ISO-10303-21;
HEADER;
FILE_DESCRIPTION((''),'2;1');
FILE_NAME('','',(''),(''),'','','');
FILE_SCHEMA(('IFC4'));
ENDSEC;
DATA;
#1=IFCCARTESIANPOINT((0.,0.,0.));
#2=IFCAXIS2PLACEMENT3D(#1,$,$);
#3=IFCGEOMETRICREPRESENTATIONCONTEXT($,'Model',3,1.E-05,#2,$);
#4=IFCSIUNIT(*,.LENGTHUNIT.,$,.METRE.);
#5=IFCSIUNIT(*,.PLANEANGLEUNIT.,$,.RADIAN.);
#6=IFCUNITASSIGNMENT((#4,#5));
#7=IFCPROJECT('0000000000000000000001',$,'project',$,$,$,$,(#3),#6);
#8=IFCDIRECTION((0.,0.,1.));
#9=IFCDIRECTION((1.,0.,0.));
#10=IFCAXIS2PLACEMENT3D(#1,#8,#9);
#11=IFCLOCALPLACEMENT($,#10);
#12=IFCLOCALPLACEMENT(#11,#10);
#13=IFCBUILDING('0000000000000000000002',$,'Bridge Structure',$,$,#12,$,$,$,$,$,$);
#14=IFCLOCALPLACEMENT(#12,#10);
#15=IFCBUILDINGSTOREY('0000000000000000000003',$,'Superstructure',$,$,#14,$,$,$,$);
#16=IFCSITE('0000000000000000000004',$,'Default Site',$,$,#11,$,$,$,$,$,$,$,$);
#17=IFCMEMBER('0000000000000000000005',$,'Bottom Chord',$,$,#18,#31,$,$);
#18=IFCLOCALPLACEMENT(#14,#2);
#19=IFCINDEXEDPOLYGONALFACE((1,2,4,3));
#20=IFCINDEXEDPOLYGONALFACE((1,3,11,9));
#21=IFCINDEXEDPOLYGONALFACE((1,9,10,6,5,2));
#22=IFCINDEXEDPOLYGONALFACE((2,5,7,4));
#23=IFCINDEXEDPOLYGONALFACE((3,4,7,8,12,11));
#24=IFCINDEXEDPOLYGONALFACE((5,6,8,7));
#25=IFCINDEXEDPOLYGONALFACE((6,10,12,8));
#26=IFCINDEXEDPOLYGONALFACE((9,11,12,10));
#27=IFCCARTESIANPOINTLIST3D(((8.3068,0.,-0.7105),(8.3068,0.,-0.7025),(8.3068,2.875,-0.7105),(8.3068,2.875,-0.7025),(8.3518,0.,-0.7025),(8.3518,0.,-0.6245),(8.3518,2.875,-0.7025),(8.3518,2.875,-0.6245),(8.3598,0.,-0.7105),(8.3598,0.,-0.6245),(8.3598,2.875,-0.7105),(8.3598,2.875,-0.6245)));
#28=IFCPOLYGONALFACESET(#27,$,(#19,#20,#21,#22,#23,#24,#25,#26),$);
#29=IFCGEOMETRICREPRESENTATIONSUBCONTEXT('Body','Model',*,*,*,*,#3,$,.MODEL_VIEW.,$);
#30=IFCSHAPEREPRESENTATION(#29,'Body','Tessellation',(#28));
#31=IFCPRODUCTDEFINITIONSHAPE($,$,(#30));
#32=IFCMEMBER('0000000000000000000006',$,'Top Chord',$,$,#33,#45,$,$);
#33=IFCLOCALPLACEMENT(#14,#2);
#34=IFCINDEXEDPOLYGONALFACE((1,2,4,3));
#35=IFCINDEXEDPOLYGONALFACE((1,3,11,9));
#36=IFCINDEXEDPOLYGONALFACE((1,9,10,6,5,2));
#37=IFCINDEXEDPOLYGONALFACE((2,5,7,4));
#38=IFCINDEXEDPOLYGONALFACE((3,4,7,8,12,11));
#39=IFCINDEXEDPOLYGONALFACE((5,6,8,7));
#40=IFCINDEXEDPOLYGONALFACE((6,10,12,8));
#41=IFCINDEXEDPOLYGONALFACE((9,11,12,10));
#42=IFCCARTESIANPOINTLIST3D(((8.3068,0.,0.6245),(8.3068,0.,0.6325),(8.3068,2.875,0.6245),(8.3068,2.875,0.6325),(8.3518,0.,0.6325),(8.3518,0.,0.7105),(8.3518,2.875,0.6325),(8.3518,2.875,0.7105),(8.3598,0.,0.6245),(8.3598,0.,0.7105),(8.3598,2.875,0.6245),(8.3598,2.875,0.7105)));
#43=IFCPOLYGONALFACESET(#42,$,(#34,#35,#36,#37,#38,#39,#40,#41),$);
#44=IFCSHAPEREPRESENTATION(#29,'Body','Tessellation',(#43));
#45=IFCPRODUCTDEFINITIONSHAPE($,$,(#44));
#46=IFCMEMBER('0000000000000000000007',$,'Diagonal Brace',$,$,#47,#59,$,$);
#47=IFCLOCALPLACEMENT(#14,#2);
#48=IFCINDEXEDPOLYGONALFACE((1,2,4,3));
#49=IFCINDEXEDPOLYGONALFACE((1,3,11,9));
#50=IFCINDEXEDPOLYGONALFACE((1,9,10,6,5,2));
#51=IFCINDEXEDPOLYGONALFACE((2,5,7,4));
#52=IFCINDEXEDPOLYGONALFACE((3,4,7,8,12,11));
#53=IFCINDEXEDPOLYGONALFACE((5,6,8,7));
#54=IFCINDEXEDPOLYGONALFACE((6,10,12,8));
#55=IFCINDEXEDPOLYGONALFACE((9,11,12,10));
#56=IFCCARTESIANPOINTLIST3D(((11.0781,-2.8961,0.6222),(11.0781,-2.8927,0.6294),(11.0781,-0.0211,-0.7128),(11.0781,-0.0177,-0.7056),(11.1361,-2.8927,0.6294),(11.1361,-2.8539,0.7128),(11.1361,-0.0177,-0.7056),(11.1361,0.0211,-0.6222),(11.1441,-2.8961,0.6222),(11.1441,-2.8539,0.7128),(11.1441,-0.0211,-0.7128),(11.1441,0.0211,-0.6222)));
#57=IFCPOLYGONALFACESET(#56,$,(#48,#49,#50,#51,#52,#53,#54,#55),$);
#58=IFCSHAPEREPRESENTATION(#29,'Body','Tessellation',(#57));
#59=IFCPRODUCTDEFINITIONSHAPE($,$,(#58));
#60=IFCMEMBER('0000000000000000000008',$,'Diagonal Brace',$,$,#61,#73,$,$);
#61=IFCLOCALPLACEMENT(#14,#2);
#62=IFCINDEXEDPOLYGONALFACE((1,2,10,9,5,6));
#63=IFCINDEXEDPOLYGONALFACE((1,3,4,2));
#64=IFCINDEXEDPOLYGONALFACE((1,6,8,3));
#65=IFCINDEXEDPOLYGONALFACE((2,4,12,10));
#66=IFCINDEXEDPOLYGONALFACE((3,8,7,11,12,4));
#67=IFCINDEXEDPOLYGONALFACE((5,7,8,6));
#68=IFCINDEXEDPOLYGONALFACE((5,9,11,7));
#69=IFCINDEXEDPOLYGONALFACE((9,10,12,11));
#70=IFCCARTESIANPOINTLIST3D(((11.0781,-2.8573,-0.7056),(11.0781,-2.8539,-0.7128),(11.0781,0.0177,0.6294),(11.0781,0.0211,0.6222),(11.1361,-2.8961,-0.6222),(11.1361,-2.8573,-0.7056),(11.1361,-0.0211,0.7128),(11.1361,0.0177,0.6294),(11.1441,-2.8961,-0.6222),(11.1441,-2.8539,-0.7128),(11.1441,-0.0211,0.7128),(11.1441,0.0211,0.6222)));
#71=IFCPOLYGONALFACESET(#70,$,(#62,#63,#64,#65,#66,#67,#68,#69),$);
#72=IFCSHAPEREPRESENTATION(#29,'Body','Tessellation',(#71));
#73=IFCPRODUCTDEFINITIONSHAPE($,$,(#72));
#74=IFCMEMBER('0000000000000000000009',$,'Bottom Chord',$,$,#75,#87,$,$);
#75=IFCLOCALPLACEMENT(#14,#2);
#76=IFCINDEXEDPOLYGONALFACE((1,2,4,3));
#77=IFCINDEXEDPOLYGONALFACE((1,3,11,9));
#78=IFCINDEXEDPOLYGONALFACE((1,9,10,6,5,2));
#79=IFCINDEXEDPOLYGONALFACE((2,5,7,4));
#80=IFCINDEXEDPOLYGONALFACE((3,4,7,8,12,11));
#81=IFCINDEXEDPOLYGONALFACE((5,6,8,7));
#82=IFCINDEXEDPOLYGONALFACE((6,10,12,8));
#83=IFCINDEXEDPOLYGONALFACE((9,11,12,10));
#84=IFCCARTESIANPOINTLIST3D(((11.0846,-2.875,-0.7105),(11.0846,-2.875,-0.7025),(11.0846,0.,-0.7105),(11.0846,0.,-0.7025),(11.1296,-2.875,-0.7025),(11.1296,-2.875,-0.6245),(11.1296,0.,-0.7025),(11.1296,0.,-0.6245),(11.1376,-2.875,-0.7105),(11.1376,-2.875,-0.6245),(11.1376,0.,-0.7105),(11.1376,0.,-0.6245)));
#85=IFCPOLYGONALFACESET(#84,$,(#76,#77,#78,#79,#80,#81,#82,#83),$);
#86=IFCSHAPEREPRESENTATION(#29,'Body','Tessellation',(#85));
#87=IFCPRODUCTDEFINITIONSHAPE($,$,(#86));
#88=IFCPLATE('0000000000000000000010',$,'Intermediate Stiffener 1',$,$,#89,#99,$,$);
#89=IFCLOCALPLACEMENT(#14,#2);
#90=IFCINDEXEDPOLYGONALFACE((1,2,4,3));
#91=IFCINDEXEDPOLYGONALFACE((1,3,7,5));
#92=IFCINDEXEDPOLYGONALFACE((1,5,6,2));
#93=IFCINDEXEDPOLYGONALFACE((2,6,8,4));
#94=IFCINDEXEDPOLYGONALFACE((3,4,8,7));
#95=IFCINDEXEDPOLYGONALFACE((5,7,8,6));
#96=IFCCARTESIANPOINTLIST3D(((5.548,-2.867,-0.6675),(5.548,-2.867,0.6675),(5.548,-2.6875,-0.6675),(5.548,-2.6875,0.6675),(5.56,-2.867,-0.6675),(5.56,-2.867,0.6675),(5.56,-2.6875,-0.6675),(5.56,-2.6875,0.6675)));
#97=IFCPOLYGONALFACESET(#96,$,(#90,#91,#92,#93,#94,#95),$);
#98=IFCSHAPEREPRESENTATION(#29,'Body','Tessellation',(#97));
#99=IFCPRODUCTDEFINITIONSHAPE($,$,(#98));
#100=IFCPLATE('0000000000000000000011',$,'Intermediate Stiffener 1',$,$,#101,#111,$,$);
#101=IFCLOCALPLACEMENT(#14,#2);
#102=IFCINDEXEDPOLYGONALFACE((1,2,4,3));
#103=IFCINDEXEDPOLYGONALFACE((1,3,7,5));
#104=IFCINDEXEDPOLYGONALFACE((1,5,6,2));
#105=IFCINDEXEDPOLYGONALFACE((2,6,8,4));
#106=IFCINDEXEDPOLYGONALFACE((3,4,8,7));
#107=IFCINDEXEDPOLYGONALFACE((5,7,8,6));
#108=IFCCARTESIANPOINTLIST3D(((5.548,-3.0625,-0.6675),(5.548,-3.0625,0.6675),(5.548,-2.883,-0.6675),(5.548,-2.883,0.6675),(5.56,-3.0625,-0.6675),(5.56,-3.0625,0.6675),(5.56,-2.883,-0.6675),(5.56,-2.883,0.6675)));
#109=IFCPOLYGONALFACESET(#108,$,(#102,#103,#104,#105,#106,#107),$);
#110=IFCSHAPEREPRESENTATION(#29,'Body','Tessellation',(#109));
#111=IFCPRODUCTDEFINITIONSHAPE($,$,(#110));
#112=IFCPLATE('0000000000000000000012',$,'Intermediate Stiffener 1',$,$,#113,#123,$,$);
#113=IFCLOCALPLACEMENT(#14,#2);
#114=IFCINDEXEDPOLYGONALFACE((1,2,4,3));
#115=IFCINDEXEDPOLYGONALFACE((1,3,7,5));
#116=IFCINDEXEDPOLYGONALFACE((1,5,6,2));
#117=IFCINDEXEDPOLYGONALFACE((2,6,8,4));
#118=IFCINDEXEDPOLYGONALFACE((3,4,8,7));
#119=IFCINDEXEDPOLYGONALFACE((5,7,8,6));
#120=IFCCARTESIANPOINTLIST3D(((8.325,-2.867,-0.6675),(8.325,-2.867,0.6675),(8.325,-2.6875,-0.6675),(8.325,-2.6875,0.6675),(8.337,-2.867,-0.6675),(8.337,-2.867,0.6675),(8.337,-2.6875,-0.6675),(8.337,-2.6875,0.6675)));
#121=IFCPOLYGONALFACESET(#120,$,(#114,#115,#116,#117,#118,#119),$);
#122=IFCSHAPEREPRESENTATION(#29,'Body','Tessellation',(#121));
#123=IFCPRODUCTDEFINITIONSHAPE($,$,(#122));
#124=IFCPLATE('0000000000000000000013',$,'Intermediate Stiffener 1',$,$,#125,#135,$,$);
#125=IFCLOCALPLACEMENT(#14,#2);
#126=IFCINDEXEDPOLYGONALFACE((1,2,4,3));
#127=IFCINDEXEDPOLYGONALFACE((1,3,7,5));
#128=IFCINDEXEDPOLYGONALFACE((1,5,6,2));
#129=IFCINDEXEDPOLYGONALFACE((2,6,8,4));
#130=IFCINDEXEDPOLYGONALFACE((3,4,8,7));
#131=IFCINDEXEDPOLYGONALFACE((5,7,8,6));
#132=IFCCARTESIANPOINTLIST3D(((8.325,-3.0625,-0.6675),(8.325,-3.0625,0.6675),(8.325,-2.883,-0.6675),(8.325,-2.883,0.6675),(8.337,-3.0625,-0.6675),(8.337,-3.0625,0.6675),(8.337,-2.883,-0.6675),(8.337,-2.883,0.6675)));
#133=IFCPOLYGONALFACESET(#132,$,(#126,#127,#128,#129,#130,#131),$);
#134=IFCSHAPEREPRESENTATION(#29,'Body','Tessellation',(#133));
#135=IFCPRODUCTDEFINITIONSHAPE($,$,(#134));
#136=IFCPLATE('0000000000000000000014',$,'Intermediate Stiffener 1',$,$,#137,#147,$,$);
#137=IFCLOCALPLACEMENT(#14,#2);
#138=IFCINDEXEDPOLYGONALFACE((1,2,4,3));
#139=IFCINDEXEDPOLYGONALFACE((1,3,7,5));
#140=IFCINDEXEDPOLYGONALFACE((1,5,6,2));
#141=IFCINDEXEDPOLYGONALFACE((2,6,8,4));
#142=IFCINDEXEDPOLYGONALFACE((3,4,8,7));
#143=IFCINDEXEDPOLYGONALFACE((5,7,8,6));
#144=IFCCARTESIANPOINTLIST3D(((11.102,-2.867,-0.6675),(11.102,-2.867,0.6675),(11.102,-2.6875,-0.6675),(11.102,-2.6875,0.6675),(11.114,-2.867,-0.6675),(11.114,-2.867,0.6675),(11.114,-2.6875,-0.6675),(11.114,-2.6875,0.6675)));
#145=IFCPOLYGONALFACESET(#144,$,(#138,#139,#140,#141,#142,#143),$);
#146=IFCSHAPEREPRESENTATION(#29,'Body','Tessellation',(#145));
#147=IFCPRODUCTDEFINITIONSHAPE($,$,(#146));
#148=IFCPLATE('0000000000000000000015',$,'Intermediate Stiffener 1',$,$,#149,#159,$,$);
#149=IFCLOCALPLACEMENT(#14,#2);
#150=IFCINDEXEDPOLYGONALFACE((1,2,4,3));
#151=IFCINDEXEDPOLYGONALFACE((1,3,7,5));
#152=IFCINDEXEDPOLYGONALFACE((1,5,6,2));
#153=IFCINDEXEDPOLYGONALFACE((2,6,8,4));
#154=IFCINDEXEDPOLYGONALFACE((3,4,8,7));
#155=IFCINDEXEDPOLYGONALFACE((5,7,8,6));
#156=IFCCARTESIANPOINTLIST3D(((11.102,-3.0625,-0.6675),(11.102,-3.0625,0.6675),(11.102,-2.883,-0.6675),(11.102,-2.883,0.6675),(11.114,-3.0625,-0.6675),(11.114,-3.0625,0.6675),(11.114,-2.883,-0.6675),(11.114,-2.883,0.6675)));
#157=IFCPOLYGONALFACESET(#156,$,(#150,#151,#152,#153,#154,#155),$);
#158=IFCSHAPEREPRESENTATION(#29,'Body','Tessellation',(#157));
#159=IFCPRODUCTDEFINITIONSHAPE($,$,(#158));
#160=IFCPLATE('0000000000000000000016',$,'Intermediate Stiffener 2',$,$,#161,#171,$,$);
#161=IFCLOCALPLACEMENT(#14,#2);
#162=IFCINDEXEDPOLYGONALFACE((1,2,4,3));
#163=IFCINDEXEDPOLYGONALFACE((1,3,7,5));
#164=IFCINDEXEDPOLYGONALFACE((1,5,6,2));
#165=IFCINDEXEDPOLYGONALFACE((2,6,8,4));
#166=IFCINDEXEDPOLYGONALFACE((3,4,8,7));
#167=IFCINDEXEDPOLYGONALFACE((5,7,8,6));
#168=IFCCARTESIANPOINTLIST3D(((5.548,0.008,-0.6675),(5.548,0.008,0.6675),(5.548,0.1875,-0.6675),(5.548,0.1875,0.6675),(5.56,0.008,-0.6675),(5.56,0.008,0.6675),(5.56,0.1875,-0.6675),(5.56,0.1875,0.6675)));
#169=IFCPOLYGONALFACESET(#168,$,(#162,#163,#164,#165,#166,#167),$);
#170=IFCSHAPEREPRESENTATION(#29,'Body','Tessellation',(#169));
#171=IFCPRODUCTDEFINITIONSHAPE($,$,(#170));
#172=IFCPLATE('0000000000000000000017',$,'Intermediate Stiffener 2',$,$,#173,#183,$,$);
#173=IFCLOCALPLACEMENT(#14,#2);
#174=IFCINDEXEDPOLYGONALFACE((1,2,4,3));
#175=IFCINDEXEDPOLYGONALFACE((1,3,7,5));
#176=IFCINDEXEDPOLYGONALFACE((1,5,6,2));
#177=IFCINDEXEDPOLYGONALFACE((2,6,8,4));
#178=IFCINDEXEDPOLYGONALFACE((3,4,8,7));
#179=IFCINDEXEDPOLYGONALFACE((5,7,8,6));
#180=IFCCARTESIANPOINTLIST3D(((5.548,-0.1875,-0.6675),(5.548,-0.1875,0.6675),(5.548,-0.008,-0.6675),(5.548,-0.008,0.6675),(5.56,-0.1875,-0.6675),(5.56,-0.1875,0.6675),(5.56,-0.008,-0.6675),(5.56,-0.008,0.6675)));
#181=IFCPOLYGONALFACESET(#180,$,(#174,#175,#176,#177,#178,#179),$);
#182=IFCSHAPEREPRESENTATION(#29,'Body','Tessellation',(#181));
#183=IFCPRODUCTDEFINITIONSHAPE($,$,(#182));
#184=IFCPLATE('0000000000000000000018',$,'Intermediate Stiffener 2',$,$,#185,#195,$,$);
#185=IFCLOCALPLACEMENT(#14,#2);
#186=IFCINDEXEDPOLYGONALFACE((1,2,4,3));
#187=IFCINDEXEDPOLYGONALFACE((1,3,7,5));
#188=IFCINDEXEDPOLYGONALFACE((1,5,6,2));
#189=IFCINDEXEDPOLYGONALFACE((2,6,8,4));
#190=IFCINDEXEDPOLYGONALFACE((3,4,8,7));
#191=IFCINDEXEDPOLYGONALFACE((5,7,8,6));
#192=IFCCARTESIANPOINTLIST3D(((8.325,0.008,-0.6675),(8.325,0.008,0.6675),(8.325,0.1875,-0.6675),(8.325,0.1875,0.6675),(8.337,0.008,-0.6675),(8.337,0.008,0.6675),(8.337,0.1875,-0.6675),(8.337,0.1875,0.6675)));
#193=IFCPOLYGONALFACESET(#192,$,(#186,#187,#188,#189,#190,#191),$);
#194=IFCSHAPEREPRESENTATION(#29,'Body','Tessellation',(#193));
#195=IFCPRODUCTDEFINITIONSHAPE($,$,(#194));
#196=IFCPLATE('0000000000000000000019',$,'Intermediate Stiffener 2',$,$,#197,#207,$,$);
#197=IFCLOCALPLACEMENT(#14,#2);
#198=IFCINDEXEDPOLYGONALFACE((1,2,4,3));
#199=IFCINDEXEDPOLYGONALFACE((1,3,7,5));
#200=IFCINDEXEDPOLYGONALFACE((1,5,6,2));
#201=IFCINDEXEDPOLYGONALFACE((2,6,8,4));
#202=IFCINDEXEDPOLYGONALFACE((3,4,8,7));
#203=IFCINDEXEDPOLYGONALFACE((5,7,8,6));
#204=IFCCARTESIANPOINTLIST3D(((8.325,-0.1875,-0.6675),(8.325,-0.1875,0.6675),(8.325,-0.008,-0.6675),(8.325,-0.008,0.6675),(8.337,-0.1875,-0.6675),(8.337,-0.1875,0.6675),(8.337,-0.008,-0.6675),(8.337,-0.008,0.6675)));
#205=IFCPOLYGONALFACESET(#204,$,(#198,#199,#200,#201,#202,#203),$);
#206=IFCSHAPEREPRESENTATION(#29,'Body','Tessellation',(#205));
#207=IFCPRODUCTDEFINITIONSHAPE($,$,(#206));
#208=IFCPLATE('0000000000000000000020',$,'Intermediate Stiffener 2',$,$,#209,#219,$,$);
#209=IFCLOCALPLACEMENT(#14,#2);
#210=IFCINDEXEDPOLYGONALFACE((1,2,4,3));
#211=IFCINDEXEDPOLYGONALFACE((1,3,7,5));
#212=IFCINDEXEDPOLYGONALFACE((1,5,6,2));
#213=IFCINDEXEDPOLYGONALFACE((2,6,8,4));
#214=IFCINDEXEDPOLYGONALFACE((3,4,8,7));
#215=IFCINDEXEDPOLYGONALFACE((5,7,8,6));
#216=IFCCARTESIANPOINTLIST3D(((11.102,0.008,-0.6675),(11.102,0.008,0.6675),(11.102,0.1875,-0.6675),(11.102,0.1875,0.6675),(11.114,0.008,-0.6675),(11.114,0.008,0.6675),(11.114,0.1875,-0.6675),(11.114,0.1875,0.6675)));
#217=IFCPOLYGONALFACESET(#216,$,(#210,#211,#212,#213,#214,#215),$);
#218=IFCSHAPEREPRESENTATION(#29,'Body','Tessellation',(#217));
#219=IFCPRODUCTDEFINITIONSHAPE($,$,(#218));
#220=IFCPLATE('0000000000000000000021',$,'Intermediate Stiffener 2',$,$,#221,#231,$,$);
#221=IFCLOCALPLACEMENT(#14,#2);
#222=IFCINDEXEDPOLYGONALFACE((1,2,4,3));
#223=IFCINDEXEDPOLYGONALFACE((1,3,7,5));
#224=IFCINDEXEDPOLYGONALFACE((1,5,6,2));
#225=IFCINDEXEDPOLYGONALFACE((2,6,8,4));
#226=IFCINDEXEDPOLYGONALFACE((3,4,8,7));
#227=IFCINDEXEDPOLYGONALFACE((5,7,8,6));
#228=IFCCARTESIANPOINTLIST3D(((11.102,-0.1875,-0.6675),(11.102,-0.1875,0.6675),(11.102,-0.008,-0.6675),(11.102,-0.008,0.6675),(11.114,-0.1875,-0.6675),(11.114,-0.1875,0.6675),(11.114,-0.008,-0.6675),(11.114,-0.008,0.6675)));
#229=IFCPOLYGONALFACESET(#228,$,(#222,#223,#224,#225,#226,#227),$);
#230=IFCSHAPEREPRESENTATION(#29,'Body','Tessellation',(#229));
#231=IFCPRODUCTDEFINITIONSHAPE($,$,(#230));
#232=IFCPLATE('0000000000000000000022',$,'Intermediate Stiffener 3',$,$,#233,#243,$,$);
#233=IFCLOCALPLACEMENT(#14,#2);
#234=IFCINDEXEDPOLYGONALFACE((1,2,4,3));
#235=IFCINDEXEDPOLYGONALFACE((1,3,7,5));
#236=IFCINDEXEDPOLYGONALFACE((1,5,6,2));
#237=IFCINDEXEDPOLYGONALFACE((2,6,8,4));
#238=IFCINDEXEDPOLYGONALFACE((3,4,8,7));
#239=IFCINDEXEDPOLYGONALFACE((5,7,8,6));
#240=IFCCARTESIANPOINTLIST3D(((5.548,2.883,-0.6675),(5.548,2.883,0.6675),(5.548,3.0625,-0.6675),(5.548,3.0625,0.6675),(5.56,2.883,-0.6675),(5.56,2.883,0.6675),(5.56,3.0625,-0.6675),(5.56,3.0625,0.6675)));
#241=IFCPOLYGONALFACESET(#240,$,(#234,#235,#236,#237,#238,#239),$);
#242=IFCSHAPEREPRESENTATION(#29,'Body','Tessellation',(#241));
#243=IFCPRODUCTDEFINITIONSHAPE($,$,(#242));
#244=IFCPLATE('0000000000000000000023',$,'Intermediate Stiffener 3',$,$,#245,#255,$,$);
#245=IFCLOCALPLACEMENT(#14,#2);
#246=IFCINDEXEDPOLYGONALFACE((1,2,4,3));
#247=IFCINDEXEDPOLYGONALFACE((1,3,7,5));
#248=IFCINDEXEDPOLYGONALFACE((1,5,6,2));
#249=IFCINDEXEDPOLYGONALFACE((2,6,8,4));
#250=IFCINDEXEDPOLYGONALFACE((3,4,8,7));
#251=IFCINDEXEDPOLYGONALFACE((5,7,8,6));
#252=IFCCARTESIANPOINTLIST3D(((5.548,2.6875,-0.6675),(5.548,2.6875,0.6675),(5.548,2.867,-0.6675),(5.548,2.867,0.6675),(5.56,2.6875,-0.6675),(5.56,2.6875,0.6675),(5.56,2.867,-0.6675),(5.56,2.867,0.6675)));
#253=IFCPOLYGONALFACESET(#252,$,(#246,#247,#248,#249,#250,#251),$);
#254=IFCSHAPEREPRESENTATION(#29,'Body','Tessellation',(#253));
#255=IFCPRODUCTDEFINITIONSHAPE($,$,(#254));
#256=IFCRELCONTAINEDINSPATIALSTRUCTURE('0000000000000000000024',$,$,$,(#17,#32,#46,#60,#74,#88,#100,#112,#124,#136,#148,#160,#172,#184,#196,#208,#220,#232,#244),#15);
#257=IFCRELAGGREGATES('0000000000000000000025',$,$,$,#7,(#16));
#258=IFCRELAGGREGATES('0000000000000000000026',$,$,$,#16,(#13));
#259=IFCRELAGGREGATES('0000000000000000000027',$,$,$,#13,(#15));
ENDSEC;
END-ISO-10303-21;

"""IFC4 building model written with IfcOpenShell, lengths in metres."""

from ifc_helpers import new_model, si_unit, frame, origin, origin_with_axes, origin_2d_with_axis, place, context, subcontext, project, spatial, rectangle, l_section, extrude, element, save


model = new_model("IFC4")

# Units and contexts
model_context = context("Model", 3, precision=1e-05, world=origin())
body_context = subcontext(model_context, "Body", "Model", "MODEL_VIEW")
ifc_project = project(units=[si_unit("LENGTHUNIT", "METRE"), si_unit("PLANEANGLEUNIT", "RADIAN")], contexts=[model_context])

# Site, building, storey
site_placement = place(None, origin_with_axes())
site = spatial("IfcSite", under=ifc_project, at=site_placement, Name="Default Site")
building_placement = place(site_placement, origin_with_axes())
building = spatial("IfcBuilding", under=site, at=building_placement, Name="Bridge Structure")
storey_placement = place(building_placement, origin_with_axes())
storey = spatial("IfcBuildingStorey", under=building, at=storey_placement, Name="Superstructure")

# Members
for number, where, z_axis, x_axis, name in (
    (1, (8.3333, 0.0, -0.6675), (0.0, 1.0, 0.0), (-1.0, 0.0, 0.0), "Bottom Chord"),
    (2, (8.3333, 0.0, 0.6675), (0.0, 1.0, 0.0), (-1.0, 0.0, 0.0), "Top Chord"),
):
    element("IfcMember", number, at=place(storey_placement, frame(where, z_axis=z_axis, x_axis=x_axis)), inside=storey, Name=name, context=body_context, shape_type="SweptSolid", body=[
        extrude(l_section(Depth=0.086, Width=0.053, Thickness=0.008, at=origin_2d_with_axis()), origin_with_axes(), (0.0, 0.0, 1.0), 2.875),
    ])
for number, where, z_axis, x_axis, name in (
    (3, (11.1111, -2.875, 0.6675), (0.0, 0.906987, -0.421158), (-1.0, 0.0, 0.0), "Diagonal Brace"),
    (4, (11.1111, -2.875, -0.6675), (0.0, 0.906987, 0.421158), (-1.0, 0.0, 0.0), "Diagonal Brace"),
):
    element("IfcMember", number, at=place(storey_placement, frame(where, z_axis=z_axis, x_axis=x_axis)), inside=storey, Name=name, context=body_context, shape_type="SweptSolid", body=[
        extrude(l_section(Depth=0.1, Width=0.066, Thickness=0.008, at=origin_2d_with_axis()), origin_with_axes(), (0.0, 0.0, 1.0), 3.1698),
    ])
member_1_placement = place(storey_placement, frame((11.1111, -2.875, -0.6675), z_axis=(0.0, 1.0, 0.0), x_axis=(-1.0, 0.0, 0.0)))
element("IfcMember", 5, at=member_1_placement, inside=storey, Name="Bottom Chord", context=body_context, shape_type="SweptSolid", body=[
    extrude(l_section(Depth=0.086, Width=0.053, Thickness=0.008, at=origin_2d_with_axis()), origin_with_axes(), (0.0, 0.0, 1.0), 2.875),
])

# Plates
for number, where, z_axis, x_axis, name in (
    (6, (5.554, -2.7772, -0.6675), (0.0, 0.0, 1.0), (1.0, 0.0, 0.0), "Intermediate Stiffener 1"),
    (7, (5.554, -2.9728, -0.6675), (0.0, 0.0, 1.0), (1.0, 0.0, 0.0), "Intermediate Stiffener 1"),
    (8, (8.331, -2.7772, -0.6675), (0.0, 0.0, 1.0), (1.0, 0.0, 0.0), "Intermediate Stiffener 1"),
    (9, (8.331, -2.9728, -0.6675), (0.0, 0.0, 1.0), (1.0, 0.0, 0.0), "Intermediate Stiffener 1"),
    (10, (11.108, -2.7772, -0.6675), (0.0, 0.0, 1.0), (1.0, 0.0, 0.0), "Intermediate Stiffener 1"),
    (11, (11.108, -2.9728, -0.6675), (0.0, 0.0, 1.0), (1.0, 0.0, 0.0), "Intermediate Stiffener 1"),
    (12, (5.554, 0.0978, -0.6675), (0.0, 0.0, 1.0), (1.0, 0.0, 0.0), "Intermediate Stiffener 2"),
    (13, (5.554, -0.0978, -0.6675), (0.0, 0.0, 1.0), (1.0, 0.0, 0.0), "Intermediate Stiffener 2"),
    (14, (8.331, 0.0978, -0.6675), (0.0, 0.0, 1.0), (1.0, 0.0, 0.0), "Intermediate Stiffener 2"),
    (15, (8.331, -0.0978, -0.6675), (0.0, 0.0, 1.0), (1.0, 0.0, 0.0), "Intermediate Stiffener 2"),
    (16, (11.108, 0.0978, -0.6675), (0.0, 0.0, 1.0), (1.0, 0.0, 0.0), "Intermediate Stiffener 2"),
    (17, (11.108, -0.0978, -0.6675), (0.0, 0.0, 1.0), (1.0, 0.0, 0.0), "Intermediate Stiffener 2"),
    (18, (5.554, 2.9728, -0.6675), (0.0, 0.0, 1.0), (1.0, 0.0, 0.0), "Intermediate Stiffener 3"),
    (19, (5.554, 2.7772, -0.6675), (0.0, 0.0, 1.0), (1.0, 0.0, 0.0), "Intermediate Stiffener 3"),
):
    element("IfcPlate", number, at=place(storey_placement, frame(where, z_axis=z_axis, x_axis=x_axis)), inside=storey, Name=name, context=body_context, shape_type="SweptSolid", body=[
        extrude(rectangle(XDim=0.012, YDim=0.1795, at=origin_2d_with_axis()), origin_with_axes(), (0.0, 0.0, 1.0), 1.335),
    ])

save(model, "model.ifc")
